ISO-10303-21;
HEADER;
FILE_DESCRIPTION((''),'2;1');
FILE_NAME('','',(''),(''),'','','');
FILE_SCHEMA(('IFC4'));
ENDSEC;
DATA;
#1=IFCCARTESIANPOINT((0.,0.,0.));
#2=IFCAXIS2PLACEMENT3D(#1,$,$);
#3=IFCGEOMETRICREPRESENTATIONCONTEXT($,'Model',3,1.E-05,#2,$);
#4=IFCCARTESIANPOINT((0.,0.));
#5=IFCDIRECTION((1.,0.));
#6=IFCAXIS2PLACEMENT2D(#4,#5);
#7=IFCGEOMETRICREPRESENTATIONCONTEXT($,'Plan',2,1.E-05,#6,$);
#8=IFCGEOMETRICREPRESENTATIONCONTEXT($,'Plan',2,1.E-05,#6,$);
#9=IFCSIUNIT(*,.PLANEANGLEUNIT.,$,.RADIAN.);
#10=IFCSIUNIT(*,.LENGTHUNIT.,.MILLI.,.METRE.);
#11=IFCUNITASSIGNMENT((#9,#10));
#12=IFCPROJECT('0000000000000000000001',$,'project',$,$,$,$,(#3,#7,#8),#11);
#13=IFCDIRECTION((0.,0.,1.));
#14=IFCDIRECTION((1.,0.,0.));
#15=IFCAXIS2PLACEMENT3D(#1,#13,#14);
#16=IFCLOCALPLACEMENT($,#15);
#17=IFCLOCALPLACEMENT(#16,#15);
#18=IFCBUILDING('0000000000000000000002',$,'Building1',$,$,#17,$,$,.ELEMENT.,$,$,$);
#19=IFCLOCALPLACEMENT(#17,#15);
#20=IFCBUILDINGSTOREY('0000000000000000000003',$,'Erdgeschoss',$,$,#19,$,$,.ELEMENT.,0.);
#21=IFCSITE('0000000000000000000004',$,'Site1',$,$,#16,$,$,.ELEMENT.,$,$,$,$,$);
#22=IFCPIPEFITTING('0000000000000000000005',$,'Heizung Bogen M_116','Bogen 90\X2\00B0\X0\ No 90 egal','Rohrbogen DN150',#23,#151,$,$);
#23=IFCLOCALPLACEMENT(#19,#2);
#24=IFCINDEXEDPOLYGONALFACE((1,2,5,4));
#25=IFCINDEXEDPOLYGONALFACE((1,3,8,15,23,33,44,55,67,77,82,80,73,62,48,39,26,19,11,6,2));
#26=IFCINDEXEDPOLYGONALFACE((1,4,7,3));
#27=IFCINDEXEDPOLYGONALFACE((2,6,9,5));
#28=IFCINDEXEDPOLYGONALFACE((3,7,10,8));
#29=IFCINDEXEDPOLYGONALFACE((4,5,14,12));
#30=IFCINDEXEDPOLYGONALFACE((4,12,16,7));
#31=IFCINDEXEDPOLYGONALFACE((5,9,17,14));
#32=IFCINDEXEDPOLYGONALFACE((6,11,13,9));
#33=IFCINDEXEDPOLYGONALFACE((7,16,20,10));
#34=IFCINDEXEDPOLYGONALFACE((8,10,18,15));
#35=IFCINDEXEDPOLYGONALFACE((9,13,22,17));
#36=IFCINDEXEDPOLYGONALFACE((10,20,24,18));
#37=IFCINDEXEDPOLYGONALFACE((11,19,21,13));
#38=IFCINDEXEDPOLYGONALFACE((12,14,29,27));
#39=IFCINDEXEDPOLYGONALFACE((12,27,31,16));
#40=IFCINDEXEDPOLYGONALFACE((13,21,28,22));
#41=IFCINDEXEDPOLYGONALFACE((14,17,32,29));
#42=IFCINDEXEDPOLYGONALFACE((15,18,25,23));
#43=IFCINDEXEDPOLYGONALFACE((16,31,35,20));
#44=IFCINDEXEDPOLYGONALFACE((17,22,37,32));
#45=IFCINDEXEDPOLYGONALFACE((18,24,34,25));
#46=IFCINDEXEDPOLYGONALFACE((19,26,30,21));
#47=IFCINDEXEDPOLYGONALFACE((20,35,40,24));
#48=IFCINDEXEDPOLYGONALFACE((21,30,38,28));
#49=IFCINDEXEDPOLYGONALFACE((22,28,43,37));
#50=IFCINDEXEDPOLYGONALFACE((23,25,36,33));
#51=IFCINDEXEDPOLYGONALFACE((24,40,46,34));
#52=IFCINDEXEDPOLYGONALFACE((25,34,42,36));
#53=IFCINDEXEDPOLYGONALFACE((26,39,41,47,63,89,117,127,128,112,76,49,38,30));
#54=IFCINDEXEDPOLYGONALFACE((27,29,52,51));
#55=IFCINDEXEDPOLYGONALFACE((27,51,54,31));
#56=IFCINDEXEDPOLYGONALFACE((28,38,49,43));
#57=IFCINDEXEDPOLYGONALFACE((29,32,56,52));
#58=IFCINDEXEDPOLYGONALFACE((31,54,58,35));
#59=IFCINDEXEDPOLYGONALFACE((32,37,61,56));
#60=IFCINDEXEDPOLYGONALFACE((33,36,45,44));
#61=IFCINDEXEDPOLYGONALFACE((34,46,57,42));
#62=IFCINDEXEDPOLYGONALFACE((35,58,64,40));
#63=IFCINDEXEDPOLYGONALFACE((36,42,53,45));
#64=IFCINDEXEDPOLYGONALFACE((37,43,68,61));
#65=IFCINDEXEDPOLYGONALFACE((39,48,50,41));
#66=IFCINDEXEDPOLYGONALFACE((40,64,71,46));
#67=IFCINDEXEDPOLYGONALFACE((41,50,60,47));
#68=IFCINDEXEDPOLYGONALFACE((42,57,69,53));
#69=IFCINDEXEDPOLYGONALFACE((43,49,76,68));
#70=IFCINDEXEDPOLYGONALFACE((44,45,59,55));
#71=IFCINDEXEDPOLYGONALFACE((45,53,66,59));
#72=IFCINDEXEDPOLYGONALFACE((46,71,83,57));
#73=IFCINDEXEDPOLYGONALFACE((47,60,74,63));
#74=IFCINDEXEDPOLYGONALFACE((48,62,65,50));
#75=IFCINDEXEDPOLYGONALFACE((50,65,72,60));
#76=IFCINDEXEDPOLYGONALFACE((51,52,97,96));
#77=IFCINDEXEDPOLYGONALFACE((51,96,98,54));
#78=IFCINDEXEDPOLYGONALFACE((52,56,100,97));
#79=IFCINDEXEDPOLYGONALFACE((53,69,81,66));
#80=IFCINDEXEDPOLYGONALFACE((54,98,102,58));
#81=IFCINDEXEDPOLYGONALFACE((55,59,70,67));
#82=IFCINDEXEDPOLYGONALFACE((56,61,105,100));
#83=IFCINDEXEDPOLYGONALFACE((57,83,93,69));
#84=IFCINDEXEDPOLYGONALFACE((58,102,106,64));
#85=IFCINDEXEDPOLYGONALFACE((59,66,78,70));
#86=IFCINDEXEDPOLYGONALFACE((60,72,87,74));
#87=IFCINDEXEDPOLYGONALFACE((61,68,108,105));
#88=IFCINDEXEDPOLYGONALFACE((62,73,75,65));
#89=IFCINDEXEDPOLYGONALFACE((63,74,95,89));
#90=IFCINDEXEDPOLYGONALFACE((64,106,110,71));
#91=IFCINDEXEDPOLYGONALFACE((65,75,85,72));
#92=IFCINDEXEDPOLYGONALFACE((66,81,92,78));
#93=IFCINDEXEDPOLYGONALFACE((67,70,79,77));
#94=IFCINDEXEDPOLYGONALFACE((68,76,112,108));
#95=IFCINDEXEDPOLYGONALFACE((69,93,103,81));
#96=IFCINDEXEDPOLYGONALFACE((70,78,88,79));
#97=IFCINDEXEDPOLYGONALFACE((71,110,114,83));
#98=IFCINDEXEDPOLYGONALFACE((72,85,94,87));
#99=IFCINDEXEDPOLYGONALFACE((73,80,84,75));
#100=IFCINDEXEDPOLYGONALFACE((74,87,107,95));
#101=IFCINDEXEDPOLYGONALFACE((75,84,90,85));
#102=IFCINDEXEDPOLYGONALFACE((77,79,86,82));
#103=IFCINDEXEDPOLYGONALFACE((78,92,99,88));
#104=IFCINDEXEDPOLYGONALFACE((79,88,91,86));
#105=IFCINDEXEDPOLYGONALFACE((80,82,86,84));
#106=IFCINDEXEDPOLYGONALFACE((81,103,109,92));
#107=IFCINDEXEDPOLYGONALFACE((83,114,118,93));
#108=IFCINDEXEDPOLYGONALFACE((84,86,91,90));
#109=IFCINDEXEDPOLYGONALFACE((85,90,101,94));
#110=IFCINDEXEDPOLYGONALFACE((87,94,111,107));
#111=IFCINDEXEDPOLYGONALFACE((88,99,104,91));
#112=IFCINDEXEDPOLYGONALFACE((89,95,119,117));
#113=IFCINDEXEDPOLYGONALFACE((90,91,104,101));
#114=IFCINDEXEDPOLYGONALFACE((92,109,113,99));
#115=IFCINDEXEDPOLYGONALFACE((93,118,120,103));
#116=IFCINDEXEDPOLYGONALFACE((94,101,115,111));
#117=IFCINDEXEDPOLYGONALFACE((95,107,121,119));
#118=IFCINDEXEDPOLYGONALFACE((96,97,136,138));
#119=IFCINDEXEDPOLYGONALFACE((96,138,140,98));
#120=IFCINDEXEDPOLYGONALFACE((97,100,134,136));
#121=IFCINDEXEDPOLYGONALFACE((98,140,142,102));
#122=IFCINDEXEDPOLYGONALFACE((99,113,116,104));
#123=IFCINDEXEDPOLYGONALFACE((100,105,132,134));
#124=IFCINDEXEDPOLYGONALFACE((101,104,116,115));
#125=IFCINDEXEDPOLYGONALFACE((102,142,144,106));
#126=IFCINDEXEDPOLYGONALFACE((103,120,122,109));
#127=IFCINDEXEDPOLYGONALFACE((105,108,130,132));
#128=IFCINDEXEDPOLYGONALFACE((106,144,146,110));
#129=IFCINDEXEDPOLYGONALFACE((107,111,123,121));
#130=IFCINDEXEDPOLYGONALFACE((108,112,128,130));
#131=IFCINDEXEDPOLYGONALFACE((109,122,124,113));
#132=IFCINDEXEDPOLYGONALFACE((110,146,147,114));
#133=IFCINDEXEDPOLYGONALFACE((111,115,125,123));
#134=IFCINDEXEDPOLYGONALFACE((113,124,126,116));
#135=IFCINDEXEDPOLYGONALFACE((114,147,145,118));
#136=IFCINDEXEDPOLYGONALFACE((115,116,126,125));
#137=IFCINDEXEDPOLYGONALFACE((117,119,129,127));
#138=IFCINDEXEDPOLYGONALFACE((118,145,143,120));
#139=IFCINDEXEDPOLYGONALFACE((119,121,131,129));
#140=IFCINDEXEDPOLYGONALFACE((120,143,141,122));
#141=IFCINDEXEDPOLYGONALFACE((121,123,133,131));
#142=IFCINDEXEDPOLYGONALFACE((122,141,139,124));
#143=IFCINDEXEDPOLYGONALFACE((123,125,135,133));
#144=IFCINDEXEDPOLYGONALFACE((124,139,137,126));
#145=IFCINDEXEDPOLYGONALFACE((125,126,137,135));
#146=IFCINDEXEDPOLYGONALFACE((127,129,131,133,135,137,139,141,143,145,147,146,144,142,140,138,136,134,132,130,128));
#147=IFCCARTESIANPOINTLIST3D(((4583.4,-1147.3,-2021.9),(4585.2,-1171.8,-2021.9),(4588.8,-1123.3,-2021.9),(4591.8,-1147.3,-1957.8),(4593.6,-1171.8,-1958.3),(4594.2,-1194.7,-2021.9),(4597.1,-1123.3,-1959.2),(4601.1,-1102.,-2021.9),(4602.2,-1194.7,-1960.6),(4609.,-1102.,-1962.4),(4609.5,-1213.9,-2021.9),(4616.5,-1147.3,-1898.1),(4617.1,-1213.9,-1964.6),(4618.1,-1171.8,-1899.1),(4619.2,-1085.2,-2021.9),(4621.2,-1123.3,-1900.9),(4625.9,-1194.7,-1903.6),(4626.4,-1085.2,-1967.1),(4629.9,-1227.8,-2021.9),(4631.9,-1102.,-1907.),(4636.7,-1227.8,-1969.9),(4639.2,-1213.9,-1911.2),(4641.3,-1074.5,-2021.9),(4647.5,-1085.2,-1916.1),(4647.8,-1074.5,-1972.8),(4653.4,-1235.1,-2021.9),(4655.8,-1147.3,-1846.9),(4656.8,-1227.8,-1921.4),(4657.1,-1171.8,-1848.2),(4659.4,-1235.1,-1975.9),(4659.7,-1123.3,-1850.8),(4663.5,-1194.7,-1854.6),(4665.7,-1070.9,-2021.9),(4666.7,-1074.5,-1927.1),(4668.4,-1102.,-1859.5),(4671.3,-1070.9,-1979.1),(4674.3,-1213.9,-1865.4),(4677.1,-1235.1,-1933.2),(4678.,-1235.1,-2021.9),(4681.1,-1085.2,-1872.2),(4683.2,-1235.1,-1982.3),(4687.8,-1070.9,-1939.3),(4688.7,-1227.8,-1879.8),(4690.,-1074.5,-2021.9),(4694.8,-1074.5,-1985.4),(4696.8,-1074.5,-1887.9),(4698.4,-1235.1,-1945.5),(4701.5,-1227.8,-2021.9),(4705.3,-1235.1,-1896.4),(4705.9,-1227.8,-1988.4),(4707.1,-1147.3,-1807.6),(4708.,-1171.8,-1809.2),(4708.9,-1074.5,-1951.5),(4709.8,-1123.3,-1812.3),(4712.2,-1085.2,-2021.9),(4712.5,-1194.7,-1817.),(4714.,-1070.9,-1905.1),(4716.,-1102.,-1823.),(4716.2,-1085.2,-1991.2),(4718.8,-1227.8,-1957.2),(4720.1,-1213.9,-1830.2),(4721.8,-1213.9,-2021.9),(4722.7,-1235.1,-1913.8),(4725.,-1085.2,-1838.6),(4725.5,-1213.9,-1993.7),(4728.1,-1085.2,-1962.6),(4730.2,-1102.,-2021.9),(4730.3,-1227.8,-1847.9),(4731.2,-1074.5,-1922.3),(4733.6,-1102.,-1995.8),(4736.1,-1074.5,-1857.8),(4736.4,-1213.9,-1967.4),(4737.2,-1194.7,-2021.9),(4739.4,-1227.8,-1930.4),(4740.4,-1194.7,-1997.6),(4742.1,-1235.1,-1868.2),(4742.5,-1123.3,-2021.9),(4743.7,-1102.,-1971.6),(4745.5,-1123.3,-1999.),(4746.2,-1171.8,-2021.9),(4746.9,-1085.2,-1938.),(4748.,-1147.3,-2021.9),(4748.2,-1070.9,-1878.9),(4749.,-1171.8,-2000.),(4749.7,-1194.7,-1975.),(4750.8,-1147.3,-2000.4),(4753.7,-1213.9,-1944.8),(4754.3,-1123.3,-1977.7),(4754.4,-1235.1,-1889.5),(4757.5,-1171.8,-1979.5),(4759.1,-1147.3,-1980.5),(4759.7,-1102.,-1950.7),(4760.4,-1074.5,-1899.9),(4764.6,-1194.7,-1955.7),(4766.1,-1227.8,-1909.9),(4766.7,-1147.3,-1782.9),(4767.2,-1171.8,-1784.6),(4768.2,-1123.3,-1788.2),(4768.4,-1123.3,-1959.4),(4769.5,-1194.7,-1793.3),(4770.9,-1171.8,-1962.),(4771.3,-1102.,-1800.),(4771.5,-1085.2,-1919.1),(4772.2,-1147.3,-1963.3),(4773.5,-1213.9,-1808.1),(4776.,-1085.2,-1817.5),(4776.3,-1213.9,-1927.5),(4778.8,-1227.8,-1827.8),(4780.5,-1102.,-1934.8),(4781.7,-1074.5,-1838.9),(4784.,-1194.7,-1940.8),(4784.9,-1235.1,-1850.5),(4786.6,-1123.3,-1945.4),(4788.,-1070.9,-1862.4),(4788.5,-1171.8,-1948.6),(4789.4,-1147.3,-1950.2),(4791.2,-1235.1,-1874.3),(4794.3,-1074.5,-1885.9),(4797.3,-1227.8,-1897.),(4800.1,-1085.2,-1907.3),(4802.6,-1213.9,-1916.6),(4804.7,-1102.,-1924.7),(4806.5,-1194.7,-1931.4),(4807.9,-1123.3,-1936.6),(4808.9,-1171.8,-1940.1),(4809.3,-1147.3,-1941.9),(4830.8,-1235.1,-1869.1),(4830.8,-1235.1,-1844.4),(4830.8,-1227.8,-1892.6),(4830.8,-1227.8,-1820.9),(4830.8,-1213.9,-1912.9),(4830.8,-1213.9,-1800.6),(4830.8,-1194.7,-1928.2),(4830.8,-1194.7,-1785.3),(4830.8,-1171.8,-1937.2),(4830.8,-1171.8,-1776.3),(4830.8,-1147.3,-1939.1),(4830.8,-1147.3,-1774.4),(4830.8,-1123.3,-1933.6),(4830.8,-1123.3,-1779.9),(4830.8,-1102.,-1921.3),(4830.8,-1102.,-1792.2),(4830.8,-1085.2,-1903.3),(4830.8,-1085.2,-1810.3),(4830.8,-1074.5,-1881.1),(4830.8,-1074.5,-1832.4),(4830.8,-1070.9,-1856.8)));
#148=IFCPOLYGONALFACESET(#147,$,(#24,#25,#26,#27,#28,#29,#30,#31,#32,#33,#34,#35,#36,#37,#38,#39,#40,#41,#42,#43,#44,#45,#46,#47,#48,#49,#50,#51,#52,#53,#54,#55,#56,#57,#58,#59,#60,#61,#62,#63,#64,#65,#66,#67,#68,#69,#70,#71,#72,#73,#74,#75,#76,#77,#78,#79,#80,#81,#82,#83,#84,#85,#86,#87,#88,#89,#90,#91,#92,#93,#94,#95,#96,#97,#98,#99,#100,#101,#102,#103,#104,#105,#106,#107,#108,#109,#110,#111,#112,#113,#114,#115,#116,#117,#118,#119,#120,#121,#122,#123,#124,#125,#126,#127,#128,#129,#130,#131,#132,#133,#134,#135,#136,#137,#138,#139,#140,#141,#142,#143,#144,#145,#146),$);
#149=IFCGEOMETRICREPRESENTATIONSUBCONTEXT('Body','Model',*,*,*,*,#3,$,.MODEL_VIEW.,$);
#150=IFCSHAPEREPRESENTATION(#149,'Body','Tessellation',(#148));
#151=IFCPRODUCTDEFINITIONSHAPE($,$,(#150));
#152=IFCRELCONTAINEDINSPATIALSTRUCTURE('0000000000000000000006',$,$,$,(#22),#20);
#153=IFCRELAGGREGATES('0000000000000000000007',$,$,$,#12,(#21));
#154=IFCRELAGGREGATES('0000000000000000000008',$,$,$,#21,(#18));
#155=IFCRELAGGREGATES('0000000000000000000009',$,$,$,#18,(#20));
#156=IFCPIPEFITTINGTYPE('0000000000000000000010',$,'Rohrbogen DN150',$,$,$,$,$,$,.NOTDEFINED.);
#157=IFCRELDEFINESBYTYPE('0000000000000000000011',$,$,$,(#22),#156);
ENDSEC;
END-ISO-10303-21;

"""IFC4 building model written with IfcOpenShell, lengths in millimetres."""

from ifc_helpers import new_model, entity, si_unit, frame, origin, origin_with_axes, origin_2d_with_axis, place, context, subcontext, project, spatial, source, transform, mapped, type_object, element, save


model = new_model("IFC4")

# Units and contexts
model_context = context("Model", 3, precision=1e-05, world=origin())
plan_context_1 = context("Plan", 2, precision=1e-05, world=origin_2d_with_axis())
plan_context_2 = context("Plan", 2, precision=1e-05, world=origin_2d_with_axis())
body_context = subcontext(model_context, "Body", "Model", "MODEL_VIEW")
ifc_project = project(units=[si_unit("PLANEANGLEUNIT", "RADIAN"), si_unit("LENGTHUNIT", "METRE", prefix="MILLI")], contexts=[model_context, plan_context_1, plan_context_2])

# Site, building, storey
site_placement = place(None, origin_with_axes())
site = spatial("IfcSite", under=ifc_project, at=site_placement, Name="Site1", CompositionType="ELEMENT")
building_placement = place(site_placement, origin_with_axes())
building = spatial("IfcBuilding", under=site, at=building_placement, Name="Building1", CompositionType="ELEMENT")
storey_placement = place(building_placement, origin_with_axes())
storey = spatial("IfcBuildingStorey", under=building, at=storey_placement, Name="Erdgeschoss", CompositionType="ELEMENT", Elevation=0.0)

# Pipe fitting
pipe_fitting_type_1 = type_object("IfcPipeFittingType", Name="Rohrbogen DN150", PredefinedType="NOTDEFINED")
shared_shape_1 = source(origin_with_axes(), body_context, "Body", "SolidModel", [
    entity("IfcRevolvedAreaSolid", entity("IfcCircleProfileDef", "AREA", None, entity("IfcAxis2Placement2D", entity("IfcCartesianPoint", [0.0, 0.0]), entity("IfcDirection", [1.0, 0.0])), 82.5), entity("IfcAxis2Placement3D", entity("IfcCartesianPoint", [123.8, 41.3, 0.0]), entity("IfcDirection", [-1.0, 0.0, 0.0]), entity("IfcDirection", [0.0, 0.0, -1.0])), entity("IfcAxis1Placement", entity("IfcCartesianPoint", [0.0, 165.1, 0.0]), entity("IfcDirection", [-1.0, 0.0, 0.0])), 1.570796),
])
pipe_fitting_1_placement = place(storey_placement, frame((4706.9, -1153.4, -1898.0), z_axis=(0.0, 0.0, 1.0), x_axis=(1.0, 0.0, 0.0)))
element("IfcPipeFitting", 1, at=pipe_fitting_1_placement, inside=storey, type_object=pipe_fitting_type_1, Name="Heizung Bogen M_116", Description="Bogen 90° No 90 egal", ObjectType="Rohrbogen DN150", context=body_context, shape_type="MappedRepresentation", body=[
    mapped(shared_shape_1, transform((0.0, 0.0, 0.0), x_axis=(1.0, 0.0, 0.0), y_axis=(0.0, 0.0, 1.0), z_axis=(0.0, -1.0, 0.0), scale=1.0)),
])

save(model, "model.ifc")
